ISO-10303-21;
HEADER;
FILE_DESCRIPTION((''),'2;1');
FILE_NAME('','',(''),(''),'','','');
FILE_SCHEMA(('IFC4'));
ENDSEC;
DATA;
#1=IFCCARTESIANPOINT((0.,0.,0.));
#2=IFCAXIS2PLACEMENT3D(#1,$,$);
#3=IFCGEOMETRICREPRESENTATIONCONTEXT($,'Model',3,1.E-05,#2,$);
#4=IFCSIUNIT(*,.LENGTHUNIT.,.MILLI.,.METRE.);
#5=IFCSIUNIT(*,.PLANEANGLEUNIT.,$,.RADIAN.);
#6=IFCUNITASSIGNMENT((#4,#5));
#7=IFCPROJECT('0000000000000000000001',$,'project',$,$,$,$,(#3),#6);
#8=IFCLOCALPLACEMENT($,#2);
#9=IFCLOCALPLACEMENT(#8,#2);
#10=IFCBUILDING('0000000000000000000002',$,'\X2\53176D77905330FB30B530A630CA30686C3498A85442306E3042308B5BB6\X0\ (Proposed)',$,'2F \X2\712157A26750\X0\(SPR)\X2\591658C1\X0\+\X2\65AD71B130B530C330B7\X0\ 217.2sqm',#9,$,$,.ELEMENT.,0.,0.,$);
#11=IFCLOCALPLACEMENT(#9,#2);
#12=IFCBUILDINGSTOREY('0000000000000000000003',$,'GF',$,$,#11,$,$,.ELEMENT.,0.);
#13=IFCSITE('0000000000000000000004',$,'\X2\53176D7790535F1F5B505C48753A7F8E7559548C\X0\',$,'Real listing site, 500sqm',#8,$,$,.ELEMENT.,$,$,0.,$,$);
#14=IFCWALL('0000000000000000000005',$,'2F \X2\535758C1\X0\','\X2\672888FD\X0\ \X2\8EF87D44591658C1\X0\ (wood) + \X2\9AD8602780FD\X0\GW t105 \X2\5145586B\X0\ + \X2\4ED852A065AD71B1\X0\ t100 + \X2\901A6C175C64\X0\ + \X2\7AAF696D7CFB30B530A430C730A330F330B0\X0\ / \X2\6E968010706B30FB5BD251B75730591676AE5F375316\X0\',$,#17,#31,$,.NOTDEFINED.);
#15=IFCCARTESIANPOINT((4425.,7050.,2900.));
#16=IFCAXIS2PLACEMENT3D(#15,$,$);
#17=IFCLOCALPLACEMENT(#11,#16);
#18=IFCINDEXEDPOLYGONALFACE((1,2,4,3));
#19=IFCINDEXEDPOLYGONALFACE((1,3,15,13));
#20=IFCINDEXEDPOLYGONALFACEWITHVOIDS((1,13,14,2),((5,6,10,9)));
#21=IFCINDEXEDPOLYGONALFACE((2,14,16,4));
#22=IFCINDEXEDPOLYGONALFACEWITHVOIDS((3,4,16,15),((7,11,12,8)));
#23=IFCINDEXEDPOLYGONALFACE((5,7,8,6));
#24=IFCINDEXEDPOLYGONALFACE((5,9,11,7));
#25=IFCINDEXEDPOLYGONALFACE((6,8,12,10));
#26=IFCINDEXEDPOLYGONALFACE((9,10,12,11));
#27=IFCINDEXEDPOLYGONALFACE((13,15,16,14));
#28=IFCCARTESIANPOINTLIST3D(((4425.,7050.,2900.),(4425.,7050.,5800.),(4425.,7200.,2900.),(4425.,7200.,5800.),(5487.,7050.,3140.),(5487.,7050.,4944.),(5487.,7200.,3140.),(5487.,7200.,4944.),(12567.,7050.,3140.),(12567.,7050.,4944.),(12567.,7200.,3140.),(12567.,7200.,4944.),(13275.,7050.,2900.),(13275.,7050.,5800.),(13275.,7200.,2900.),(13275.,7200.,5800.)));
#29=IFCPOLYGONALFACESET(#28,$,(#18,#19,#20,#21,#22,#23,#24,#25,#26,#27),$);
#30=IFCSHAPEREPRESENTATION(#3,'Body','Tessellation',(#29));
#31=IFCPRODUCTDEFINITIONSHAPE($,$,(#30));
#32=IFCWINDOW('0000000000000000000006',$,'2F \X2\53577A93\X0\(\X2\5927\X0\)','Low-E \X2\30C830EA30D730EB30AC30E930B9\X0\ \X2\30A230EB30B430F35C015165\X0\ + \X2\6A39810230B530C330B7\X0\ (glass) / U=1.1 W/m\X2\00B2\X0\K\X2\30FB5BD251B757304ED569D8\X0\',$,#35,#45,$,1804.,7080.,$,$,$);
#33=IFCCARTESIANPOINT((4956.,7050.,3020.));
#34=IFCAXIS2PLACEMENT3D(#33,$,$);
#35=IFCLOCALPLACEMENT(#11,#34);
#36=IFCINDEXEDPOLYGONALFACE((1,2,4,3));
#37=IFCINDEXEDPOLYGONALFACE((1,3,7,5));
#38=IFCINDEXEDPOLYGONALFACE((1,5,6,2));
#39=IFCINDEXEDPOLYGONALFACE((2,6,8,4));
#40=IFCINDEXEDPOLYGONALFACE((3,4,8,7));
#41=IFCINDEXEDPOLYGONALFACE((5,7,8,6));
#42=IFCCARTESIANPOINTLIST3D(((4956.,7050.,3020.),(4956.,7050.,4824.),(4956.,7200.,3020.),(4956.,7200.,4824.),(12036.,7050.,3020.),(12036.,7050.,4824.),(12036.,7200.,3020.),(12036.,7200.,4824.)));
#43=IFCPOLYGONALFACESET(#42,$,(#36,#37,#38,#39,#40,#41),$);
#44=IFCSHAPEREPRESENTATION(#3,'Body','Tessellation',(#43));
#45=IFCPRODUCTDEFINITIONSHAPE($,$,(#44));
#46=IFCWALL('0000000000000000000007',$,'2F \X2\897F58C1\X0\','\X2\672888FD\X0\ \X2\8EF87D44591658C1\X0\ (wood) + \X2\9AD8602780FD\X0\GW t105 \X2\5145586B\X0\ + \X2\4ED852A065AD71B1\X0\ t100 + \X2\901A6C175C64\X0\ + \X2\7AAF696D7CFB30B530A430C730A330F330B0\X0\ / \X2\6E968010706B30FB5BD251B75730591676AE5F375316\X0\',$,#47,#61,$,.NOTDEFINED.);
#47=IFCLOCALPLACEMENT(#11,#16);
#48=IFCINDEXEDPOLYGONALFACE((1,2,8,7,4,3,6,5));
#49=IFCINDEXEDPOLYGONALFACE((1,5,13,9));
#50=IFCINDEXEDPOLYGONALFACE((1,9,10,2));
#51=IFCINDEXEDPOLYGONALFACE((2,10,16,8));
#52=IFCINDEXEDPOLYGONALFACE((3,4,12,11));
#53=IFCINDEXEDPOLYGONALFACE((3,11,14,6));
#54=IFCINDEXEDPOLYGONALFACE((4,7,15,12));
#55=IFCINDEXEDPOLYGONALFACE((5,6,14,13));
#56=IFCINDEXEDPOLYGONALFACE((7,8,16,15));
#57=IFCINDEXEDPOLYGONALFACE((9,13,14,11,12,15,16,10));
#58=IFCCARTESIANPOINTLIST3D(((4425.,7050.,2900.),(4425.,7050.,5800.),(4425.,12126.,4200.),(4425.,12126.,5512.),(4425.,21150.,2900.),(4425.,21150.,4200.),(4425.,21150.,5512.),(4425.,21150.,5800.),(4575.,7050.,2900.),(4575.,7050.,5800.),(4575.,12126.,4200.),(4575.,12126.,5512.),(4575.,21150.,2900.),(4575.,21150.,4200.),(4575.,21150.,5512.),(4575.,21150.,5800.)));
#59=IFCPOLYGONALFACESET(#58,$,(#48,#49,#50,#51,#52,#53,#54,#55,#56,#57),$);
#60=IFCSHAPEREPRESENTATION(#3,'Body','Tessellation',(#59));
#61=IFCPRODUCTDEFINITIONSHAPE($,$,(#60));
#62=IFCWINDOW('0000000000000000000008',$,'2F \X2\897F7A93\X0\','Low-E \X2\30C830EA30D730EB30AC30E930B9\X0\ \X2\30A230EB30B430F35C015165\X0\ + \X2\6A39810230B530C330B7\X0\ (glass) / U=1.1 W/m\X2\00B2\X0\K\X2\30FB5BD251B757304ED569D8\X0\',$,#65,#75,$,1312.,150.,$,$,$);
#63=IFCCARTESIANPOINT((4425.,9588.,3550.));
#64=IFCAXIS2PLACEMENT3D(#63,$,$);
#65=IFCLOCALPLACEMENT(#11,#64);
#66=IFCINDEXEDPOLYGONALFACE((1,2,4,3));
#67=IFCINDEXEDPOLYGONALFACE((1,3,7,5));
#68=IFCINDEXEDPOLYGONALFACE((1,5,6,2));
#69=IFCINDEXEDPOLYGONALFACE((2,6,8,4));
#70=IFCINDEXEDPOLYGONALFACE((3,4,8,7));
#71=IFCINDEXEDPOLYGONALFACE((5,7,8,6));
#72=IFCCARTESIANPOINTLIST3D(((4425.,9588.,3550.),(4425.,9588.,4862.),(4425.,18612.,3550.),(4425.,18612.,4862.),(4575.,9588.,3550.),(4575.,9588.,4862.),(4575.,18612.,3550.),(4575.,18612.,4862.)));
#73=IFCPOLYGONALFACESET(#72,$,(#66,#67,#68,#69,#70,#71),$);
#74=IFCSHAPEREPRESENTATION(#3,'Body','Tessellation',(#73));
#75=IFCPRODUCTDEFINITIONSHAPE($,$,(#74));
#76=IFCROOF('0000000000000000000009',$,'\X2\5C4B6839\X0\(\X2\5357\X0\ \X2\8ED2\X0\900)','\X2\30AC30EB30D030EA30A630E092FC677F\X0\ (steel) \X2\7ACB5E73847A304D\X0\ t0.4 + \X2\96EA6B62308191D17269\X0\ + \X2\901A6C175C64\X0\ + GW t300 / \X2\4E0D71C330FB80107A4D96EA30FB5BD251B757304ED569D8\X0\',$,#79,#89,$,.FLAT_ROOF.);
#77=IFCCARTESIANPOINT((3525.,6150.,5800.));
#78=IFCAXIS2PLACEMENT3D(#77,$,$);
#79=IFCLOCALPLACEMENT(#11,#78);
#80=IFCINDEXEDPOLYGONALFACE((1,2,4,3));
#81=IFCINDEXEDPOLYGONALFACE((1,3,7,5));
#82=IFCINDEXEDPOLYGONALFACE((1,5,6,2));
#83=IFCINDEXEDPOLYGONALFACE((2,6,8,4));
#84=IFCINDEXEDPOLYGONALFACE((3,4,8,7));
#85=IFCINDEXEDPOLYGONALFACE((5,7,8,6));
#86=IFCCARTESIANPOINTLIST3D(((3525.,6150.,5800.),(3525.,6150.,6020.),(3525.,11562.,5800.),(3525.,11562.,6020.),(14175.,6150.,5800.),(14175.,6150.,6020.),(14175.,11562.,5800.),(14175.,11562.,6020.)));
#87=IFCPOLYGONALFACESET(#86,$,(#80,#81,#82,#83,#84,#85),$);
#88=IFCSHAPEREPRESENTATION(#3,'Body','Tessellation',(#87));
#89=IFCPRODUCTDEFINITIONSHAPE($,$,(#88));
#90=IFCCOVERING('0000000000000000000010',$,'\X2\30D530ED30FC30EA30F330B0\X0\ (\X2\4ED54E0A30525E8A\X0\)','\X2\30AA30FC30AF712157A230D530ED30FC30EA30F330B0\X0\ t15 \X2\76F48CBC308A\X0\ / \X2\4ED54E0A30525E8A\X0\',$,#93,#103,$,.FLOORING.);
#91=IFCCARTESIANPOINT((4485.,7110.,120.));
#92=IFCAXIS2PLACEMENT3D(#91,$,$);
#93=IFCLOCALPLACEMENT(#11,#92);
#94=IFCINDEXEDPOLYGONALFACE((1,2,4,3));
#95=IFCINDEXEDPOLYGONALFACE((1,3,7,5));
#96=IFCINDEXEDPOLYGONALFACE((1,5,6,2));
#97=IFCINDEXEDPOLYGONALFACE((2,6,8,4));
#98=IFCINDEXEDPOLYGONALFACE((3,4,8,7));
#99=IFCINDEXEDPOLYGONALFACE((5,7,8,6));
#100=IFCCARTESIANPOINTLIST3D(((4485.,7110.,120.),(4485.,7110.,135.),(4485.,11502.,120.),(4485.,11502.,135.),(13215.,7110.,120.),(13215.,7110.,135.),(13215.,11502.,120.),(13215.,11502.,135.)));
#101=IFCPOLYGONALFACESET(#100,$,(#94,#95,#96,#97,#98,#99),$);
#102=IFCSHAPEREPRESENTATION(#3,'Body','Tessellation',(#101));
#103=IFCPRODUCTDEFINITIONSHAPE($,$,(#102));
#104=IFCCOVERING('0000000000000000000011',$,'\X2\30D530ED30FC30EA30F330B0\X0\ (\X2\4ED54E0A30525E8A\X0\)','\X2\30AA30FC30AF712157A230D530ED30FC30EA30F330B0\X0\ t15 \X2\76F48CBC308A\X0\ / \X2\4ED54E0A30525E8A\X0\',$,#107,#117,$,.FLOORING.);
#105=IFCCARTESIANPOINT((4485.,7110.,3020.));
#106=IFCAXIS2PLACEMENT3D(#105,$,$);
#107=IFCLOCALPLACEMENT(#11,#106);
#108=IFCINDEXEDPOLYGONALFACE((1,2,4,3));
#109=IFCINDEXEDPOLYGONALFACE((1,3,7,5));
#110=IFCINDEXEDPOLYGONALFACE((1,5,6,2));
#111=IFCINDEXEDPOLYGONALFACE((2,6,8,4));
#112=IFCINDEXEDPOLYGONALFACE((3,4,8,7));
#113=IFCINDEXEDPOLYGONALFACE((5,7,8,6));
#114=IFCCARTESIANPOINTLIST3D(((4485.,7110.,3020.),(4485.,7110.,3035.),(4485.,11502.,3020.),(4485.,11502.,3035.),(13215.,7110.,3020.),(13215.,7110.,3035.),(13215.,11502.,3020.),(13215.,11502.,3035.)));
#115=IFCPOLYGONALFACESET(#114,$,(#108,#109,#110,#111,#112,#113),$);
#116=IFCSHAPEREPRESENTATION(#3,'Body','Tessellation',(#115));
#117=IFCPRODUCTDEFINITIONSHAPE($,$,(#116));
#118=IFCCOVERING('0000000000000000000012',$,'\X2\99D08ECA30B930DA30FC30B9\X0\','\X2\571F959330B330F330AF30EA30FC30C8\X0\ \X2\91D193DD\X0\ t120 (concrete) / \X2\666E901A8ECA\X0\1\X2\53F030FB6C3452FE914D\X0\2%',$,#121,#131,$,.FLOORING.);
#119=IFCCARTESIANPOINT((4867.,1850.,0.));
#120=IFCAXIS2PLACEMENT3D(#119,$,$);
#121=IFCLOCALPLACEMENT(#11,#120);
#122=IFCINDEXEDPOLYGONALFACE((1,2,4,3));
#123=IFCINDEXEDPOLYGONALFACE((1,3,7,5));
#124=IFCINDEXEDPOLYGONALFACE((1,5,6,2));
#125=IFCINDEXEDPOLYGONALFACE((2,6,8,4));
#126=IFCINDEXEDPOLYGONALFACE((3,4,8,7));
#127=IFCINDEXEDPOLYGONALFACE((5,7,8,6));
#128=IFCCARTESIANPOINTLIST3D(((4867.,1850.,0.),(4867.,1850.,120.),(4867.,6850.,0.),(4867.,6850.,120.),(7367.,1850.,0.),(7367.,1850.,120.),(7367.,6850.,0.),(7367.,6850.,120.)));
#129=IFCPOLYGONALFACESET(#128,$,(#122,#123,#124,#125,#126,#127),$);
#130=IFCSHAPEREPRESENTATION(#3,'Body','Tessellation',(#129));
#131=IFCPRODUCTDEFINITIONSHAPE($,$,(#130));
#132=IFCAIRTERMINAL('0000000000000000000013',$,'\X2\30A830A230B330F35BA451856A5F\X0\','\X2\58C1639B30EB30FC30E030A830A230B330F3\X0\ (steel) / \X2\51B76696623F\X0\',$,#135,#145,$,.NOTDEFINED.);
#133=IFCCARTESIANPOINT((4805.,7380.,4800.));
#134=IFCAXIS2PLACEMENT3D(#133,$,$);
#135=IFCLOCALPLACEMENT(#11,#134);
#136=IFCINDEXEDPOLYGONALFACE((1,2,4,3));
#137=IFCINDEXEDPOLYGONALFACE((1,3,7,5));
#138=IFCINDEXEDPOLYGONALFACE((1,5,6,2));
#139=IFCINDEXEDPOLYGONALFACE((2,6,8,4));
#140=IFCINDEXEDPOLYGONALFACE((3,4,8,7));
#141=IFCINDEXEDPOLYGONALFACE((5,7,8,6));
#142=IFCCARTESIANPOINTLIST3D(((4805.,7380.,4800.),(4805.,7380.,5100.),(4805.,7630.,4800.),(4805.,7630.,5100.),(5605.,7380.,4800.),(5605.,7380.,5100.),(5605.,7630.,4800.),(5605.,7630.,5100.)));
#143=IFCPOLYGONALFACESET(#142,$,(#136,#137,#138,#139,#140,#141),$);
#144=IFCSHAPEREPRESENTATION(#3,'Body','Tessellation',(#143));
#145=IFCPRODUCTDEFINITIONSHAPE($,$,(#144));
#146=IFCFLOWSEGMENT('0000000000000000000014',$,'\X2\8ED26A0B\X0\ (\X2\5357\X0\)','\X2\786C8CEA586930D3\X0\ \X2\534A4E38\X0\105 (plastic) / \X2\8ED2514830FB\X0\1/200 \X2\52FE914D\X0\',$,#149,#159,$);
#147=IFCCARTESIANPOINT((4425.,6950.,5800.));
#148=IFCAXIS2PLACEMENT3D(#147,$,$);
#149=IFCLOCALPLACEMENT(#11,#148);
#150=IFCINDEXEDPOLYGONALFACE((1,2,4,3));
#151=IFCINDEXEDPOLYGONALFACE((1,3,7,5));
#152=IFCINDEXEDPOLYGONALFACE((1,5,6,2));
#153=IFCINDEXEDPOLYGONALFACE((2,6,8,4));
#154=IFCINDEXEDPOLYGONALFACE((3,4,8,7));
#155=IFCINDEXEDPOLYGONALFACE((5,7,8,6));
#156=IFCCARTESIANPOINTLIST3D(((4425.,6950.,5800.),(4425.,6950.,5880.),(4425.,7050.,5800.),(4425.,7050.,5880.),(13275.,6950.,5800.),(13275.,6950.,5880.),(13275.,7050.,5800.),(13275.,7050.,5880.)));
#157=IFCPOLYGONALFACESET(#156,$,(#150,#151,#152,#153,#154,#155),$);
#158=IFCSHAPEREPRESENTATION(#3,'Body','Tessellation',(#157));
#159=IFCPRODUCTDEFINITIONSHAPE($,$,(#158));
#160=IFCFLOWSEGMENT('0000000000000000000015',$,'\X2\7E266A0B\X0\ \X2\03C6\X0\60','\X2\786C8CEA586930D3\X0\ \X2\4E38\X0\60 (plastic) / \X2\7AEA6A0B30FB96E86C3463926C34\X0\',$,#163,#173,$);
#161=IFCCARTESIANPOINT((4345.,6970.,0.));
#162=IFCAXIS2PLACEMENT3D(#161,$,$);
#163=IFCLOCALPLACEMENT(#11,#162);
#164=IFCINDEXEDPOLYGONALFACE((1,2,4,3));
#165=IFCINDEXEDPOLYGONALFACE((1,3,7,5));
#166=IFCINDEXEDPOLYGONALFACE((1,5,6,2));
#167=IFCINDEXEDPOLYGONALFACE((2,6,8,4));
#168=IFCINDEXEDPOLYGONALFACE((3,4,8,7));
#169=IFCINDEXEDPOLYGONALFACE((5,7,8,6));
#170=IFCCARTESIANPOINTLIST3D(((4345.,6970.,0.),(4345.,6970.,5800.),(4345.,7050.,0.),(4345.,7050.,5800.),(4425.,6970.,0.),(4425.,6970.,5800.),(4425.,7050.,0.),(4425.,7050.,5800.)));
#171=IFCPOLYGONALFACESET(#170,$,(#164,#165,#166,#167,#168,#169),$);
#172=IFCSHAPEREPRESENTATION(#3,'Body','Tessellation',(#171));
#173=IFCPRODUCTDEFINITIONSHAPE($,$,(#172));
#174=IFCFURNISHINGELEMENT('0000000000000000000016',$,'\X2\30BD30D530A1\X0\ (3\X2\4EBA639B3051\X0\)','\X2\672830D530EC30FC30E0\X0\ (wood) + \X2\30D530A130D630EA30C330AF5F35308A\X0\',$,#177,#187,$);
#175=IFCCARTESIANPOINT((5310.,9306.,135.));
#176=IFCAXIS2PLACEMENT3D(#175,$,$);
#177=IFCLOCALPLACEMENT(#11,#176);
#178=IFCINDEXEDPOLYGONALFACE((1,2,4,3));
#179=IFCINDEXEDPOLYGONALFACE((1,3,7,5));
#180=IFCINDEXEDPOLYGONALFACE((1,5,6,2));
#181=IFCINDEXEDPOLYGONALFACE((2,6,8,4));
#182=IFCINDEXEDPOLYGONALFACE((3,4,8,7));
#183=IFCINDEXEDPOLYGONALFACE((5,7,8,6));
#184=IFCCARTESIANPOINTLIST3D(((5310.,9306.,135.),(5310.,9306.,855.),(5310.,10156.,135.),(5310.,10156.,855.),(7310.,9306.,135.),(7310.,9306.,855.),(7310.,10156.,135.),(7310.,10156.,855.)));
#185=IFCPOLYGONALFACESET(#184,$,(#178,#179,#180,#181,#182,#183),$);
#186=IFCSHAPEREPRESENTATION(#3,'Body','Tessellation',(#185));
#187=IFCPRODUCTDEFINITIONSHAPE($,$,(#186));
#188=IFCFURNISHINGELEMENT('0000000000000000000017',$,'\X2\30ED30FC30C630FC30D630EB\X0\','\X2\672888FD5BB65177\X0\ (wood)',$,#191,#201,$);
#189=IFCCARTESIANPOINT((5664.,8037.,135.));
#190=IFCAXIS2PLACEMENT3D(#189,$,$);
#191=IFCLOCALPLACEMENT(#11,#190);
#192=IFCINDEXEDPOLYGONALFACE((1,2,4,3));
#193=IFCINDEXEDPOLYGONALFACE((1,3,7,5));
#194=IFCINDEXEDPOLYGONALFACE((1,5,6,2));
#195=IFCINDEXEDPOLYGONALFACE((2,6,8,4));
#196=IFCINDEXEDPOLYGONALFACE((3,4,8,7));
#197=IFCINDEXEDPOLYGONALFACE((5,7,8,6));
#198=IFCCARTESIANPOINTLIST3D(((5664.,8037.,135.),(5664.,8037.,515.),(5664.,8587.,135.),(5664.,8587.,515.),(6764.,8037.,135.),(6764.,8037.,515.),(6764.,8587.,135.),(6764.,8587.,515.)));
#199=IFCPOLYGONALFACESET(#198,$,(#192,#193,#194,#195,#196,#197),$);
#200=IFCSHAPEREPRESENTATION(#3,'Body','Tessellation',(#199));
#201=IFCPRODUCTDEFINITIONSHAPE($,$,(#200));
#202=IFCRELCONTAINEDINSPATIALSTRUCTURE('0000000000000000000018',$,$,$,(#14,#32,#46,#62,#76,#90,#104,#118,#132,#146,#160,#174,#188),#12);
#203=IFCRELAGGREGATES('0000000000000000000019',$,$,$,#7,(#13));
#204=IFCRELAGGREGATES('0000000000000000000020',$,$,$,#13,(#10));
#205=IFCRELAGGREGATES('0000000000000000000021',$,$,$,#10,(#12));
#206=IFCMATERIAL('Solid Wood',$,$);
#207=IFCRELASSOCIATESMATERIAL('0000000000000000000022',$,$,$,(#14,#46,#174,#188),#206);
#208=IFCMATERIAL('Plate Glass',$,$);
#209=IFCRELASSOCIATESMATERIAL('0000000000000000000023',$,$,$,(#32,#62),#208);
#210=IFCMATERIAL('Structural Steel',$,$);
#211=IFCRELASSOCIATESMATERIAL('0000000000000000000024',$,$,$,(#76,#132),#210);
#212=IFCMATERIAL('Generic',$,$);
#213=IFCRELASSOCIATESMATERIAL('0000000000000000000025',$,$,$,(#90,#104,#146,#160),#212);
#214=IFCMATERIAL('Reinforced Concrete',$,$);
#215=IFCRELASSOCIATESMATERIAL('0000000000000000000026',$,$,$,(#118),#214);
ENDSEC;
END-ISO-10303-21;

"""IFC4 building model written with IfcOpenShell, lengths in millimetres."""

from ifc_helpers import new_model, si_unit, frame, frame_2d, origin, place, context, project, spatial, rectangle, extrude, material, element, fill, save


model = new_model("IFC4")

# Units and contexts
model_context = context("Model", 3, precision=1e-05, world=origin())
ifc_project = project(units=[si_unit("LENGTHUNIT", "METRE", prefix="MILLI"), si_unit("PLANEANGLEUNIT", "RADIAN")], contexts=[model_context])

# Site, building, storey
site_placement = place(None, origin())
site = spatial("IfcSite", under=ifc_project, at=site_placement, Name="北海道弟子屈町美留和", ObjectType="Real listing site, 500sqm", CompositionType="ELEMENT", RefElevation=0.0)
building_placement = place(site_placement, origin())
building = spatial("IfcBuilding", under=site, at=building_placement, Name="北海道・サウナと水風呂のある家 (Proposed)", ObjectType="2F 無垢材(SPR)外壁+断熱サッシ 217.2sqm", CompositionType="ELEMENT", ElevationOfRefHeight=0.0, ElevationOfTerrain=0.0)
storey_placement = place(building_placement, origin())
storey = spatial("IfcBuildingStorey", under=building, at=storey_placement, Name="GF", CompositionType="ELEMENT", Elevation=0.0)

# Shared definitions
ifc_material_1 = material(Name="Solid Wood")

# Shared definitions
ifc_material_2 = material(Name="Reinforced Concrete")

# Shared definitions
ifc_material_3 = material(Name="Plate Glass")

# Walls, openings, windows
wall_1_placement = place(storey_placement, frame((4425.0, 7050.0, 2900.0)))
wall_1 = element("IfcWall", 1, at=wall_1_placement, inside=storey, material=ifc_material_1, Name="2F 南壁", Description="木製 軸組外壁 (wood) + 高性能GW t105 充填 + 付加断熱 t100 + 通気層 + 窯業系サイディング / 準耐火・寒冷地外皮強化", PredefinedType="NOTDEFINED", context=model_context, shape_type="SweptSolid", body=[
    extrude(rectangle(XDim=8850.0, YDim=150.0, at=frame_2d((4425.0, 75.0))), frame((4425.0, 7050.0, 2900.0)), (0.0, 0.0, 1.0), 2900.0),
])
opening_1_placement = place(storey_placement, frame((4956.0, 7050.0, 3020.0)))
opening_1 = element("IfcOpeningElement", 2, at=opening_1_placement, cuts=wall_1, PredefinedType="NOTDEFINED", context=model_context, shape_type="SweptSolid", body=[
    extrude(rectangle(XDim=7080.0, YDim=150.0, at=frame_2d((3540.0, 75.0))), frame((4956.0, 7050.0, 3020.0)), (0.0, 0.0, 1.0), 1804.0),
])
window_1_placement = place(storey_placement, frame((4956.0, 7050.0, 3020.0)))
window_1 = element("IfcWindow", 3, at=window_1_placement, inside=storey, material=ifc_material_3, Name="2F 南窓(大)", Description="Low-E トリプルガラス アルゴン封入 + 樹脂サッシ (glass) / U=1.1 W/m²K・寒冷地仕様", OverallHeight=1804.0, OverallWidth=7080.0, context=model_context, shape_type="SweptSolid", body=[
    extrude(rectangle(XDim=7080.0, YDim=150.0, at=frame_2d((3540.0, 75.0))), frame((4956.0, 7050.0, 3020.0)), (0.0, 0.0, 1.0), 1804.0),
])
fill(opening_1, window_1)
wall_2_placement = place(storey_placement, frame((4425.0, 7050.0, 2900.0)))
wall_2 = element("IfcWall", 4, at=wall_2_placement, inside=storey, material=ifc_material_1, Name="2F 西壁", Description="木製 軸組外壁 (wood) + 高性能GW t105 充填 + 付加断熱 t100 + 通気層 + 窯業系サイディング / 準耐火・寒冷地外皮強化", PredefinedType="NOTDEFINED", context=model_context, shape_type="SweptSolid", body=[
    extrude(rectangle(XDim=150.0, YDim=14100.0, at=frame_2d((75.0, 7050.0))), frame((4425.0, 7050.0, 2900.0)), (0.0, 0.0, 1.0), 2900.0),
])
opening_2_placement = place(storey_placement, frame((4425.0, 9588.0, 3550.0)))
opening_2 = element("IfcOpeningElement", 5, at=opening_2_placement, cuts=wall_2, PredefinedType="NOTDEFINED", context=model_context, shape_type="SweptSolid", body=[
    extrude(rectangle(XDim=150.0, YDim=9024.0, at=frame_2d((75.0, 4512.0))), frame((4425.0, 9588.0, 3550.0)), (0.0, 0.0, 1.0), 1312.0),
])
window_2_placement = place(storey_placement, frame((4425.0, 9588.0, 3550.0)))
window_2 = element("IfcWindow", 6, at=window_2_placement, inside=storey, material=ifc_material_3, Name="2F 西窓", Description="Low-E トリプルガラス アルゴン封入 + 樹脂サッシ (glass) / U=1.1 W/m²K・寒冷地仕様", OverallHeight=1312.0, OverallWidth=150.0, context=model_context, shape_type="SweptSolid", body=[
    extrude(rectangle(XDim=150.0, YDim=9024.0, at=frame_2d((75.0, 4512.0))), frame((4425.0, 9588.0, 3550.0)), (0.0, 0.0, 1.0), 1312.0),
])
fill(opening_2, window_2)

# Roof
ifc_material_4 = material(Name="Structural Steel")
for number, where, name in (
    (7, (3525.0, 6150.0, 5800.0), "屋根(南 軒900)"),
):
    element("IfcRoof", number, at=place(storey_placement, frame(where)), inside=storey, material=ifc_material_4, Name=name, Description="ガルバリウム鋼板 (steel) 立平葺き t0.4 + 雪止め金物 + 通気層 + GW t300 / 不燃・耐積雪・寒冷地仕様", PredefinedType="FLAT_ROOF", context=model_context, shape_type="SweptSolid", body=[
        extrude(rectangle(XDim=10650.0, YDim=5412.0, at=frame_2d((5325.0, 2706.0))), frame((3525.0, 6150.0, 5800.0)), (0.0, 0.0, 1.0), 220.0),
    ])

# Coverings
ifc_material_5 = material(Name="Generic")
covering_1_placement = place(storey_placement, frame((4485.0, 7110.0, 120.0)))
element("IfcCovering", 8, at=covering_1_placement, inside=storey, material=ifc_material_5, Name="フローリング (仕上げ床)", Description="オーク無垢フローリング t15 直貼り / 仕上げ床", PredefinedType="FLOORING", context=model_context, shape_type="SweptSolid", body=[
    extrude(rectangle(XDim=8730.0, YDim=4392.0, at=frame_2d((4365.0, 2196.0))), frame((4485.0, 7110.0, 120.0)), (0.0, 0.0, 1.0), 15.0),
])
covering_2_placement = place(storey_placement, frame((4485.0, 7110.0, 3020.0)))
element("IfcCovering", 9, at=covering_2_placement, inside=storey, material=ifc_material_5, Name="フローリング (仕上げ床)", Description="オーク無垢フローリング t15 直貼り / 仕上げ床", PredefinedType="FLOORING", context=model_context, shape_type="SweptSolid", body=[
    extrude(rectangle(XDim=8730.0, YDim=4392.0, at=frame_2d((4365.0, 2196.0))), frame((4485.0, 7110.0, 3020.0)), (0.0, 0.0, 1.0), 15.0),
])
covering_3_placement = place(storey_placement, frame((4867.0, 1850.0, 0.0)))
element("IfcCovering", 10, at=covering_3_placement, inside=storey, material=ifc_material_2, Name="駐車スペース", Description="土間コンクリート 金鏝 t120 (concrete) / 普通車1台・水勾配2%", PredefinedType="FLOORING", context=model_context, shape_type="SweptSolid", body=[
    extrude(rectangle(XDim=2500.0, YDim=5000.0, at=frame_2d((1250.0, 2500.0))), frame((4867.0, 1850.0, 0.0)), (0.0, 0.0, 1.0), 120.0),
])

# Air terminal
air_terminal_placement = place(storey_placement, frame((4805.0, 7380.0, 4800.0)))
element("IfcAirTerminal", 11, at=air_terminal_placement, inside=storey, material=ifc_material_4, Name="エアコン室内機", Description="壁掛ルームエアコン (steel) / 冷暖房", PredefinedType="NOTDEFINED", context=model_context, shape_type="SweptSolid", body=[
    extrude(rectangle(XDim=800.0, YDim=250.0, at=frame_2d((400.0, 125.0))), frame((4805.0, 7380.0, 4800.0)), (0.0, 0.0, 1.0), 300.0),
])

# Flow segments
flow_segment_1_placement = place(storey_placement, frame((4425.0, 6950.0, 5800.0)))
element("IfcFlowSegment", 12, at=flow_segment_1_placement, inside=storey, material=ifc_material_5, Name="軒樋 (南)", Description="硬質塩ビ 半丸105 (plastic) / 軒先・1/200 勾配", context=model_context, shape_type="SweptSolid", body=[
    extrude(rectangle(XDim=8850.0, YDim=100.0, at=frame_2d((4425.0, 50.0))), frame((4425.0, 6950.0, 5800.0)), (0.0, 0.0, 1.0), 80.0),
])
flow_segment_2_placement = place(storey_placement, frame((4345.0, 6970.0, 0.0)))
element("IfcFlowSegment", 13, at=flow_segment_2_placement, inside=storey, material=ifc_material_5, Name="縦樋 φ60", Description="硬質塩ビ 丸60 (plastic) / 竪樋・雨水排水", context=model_context, shape_type="SweptSolid", body=[
    extrude(rectangle(XDim=80.0, YDim=80.0, at=frame_2d((40.0, 40.0))), frame((4345.0, 6970.0, 0.0)), (0.0, 0.0, 1.0), 5800.0),
])

# Furnishing elements
furnishing_1_placement = place(storey_placement, frame((5310.0, 9306.0, 135.0)))
element("IfcFurnishingElement", 14, at=furnishing_1_placement, inside=storey, material=ifc_material_1, Name="ソファ (3人掛け)", Description="木フレーム (wood) + ファブリック張り", context=model_context, shape_type="SweptSolid", body=[
    extrude(rectangle(XDim=2000.0, YDim=850.0, at=frame_2d((1000.0, 425.0))), frame((5310.0, 9306.0, 135.0)), (0.0, 0.0, 1.0), 720.0),
])
furnishing_2_placement = place(storey_placement, frame((5664.0, 8037.0, 135.0)))
element("IfcFurnishingElement", 15, at=furnishing_2_placement, inside=storey, material=ifc_material_1, Name="ローテーブル", Description="木製家具 (wood)", context=model_context, shape_type="SweptSolid", body=[
    extrude(rectangle(XDim=1100.0, YDim=550.0, at=frame_2d((550.0, 275.0))), frame((5664.0, 8037.0, 135.0)), (0.0, 0.0, 1.0), 380.0),
])

save(model, "model.ifc")
